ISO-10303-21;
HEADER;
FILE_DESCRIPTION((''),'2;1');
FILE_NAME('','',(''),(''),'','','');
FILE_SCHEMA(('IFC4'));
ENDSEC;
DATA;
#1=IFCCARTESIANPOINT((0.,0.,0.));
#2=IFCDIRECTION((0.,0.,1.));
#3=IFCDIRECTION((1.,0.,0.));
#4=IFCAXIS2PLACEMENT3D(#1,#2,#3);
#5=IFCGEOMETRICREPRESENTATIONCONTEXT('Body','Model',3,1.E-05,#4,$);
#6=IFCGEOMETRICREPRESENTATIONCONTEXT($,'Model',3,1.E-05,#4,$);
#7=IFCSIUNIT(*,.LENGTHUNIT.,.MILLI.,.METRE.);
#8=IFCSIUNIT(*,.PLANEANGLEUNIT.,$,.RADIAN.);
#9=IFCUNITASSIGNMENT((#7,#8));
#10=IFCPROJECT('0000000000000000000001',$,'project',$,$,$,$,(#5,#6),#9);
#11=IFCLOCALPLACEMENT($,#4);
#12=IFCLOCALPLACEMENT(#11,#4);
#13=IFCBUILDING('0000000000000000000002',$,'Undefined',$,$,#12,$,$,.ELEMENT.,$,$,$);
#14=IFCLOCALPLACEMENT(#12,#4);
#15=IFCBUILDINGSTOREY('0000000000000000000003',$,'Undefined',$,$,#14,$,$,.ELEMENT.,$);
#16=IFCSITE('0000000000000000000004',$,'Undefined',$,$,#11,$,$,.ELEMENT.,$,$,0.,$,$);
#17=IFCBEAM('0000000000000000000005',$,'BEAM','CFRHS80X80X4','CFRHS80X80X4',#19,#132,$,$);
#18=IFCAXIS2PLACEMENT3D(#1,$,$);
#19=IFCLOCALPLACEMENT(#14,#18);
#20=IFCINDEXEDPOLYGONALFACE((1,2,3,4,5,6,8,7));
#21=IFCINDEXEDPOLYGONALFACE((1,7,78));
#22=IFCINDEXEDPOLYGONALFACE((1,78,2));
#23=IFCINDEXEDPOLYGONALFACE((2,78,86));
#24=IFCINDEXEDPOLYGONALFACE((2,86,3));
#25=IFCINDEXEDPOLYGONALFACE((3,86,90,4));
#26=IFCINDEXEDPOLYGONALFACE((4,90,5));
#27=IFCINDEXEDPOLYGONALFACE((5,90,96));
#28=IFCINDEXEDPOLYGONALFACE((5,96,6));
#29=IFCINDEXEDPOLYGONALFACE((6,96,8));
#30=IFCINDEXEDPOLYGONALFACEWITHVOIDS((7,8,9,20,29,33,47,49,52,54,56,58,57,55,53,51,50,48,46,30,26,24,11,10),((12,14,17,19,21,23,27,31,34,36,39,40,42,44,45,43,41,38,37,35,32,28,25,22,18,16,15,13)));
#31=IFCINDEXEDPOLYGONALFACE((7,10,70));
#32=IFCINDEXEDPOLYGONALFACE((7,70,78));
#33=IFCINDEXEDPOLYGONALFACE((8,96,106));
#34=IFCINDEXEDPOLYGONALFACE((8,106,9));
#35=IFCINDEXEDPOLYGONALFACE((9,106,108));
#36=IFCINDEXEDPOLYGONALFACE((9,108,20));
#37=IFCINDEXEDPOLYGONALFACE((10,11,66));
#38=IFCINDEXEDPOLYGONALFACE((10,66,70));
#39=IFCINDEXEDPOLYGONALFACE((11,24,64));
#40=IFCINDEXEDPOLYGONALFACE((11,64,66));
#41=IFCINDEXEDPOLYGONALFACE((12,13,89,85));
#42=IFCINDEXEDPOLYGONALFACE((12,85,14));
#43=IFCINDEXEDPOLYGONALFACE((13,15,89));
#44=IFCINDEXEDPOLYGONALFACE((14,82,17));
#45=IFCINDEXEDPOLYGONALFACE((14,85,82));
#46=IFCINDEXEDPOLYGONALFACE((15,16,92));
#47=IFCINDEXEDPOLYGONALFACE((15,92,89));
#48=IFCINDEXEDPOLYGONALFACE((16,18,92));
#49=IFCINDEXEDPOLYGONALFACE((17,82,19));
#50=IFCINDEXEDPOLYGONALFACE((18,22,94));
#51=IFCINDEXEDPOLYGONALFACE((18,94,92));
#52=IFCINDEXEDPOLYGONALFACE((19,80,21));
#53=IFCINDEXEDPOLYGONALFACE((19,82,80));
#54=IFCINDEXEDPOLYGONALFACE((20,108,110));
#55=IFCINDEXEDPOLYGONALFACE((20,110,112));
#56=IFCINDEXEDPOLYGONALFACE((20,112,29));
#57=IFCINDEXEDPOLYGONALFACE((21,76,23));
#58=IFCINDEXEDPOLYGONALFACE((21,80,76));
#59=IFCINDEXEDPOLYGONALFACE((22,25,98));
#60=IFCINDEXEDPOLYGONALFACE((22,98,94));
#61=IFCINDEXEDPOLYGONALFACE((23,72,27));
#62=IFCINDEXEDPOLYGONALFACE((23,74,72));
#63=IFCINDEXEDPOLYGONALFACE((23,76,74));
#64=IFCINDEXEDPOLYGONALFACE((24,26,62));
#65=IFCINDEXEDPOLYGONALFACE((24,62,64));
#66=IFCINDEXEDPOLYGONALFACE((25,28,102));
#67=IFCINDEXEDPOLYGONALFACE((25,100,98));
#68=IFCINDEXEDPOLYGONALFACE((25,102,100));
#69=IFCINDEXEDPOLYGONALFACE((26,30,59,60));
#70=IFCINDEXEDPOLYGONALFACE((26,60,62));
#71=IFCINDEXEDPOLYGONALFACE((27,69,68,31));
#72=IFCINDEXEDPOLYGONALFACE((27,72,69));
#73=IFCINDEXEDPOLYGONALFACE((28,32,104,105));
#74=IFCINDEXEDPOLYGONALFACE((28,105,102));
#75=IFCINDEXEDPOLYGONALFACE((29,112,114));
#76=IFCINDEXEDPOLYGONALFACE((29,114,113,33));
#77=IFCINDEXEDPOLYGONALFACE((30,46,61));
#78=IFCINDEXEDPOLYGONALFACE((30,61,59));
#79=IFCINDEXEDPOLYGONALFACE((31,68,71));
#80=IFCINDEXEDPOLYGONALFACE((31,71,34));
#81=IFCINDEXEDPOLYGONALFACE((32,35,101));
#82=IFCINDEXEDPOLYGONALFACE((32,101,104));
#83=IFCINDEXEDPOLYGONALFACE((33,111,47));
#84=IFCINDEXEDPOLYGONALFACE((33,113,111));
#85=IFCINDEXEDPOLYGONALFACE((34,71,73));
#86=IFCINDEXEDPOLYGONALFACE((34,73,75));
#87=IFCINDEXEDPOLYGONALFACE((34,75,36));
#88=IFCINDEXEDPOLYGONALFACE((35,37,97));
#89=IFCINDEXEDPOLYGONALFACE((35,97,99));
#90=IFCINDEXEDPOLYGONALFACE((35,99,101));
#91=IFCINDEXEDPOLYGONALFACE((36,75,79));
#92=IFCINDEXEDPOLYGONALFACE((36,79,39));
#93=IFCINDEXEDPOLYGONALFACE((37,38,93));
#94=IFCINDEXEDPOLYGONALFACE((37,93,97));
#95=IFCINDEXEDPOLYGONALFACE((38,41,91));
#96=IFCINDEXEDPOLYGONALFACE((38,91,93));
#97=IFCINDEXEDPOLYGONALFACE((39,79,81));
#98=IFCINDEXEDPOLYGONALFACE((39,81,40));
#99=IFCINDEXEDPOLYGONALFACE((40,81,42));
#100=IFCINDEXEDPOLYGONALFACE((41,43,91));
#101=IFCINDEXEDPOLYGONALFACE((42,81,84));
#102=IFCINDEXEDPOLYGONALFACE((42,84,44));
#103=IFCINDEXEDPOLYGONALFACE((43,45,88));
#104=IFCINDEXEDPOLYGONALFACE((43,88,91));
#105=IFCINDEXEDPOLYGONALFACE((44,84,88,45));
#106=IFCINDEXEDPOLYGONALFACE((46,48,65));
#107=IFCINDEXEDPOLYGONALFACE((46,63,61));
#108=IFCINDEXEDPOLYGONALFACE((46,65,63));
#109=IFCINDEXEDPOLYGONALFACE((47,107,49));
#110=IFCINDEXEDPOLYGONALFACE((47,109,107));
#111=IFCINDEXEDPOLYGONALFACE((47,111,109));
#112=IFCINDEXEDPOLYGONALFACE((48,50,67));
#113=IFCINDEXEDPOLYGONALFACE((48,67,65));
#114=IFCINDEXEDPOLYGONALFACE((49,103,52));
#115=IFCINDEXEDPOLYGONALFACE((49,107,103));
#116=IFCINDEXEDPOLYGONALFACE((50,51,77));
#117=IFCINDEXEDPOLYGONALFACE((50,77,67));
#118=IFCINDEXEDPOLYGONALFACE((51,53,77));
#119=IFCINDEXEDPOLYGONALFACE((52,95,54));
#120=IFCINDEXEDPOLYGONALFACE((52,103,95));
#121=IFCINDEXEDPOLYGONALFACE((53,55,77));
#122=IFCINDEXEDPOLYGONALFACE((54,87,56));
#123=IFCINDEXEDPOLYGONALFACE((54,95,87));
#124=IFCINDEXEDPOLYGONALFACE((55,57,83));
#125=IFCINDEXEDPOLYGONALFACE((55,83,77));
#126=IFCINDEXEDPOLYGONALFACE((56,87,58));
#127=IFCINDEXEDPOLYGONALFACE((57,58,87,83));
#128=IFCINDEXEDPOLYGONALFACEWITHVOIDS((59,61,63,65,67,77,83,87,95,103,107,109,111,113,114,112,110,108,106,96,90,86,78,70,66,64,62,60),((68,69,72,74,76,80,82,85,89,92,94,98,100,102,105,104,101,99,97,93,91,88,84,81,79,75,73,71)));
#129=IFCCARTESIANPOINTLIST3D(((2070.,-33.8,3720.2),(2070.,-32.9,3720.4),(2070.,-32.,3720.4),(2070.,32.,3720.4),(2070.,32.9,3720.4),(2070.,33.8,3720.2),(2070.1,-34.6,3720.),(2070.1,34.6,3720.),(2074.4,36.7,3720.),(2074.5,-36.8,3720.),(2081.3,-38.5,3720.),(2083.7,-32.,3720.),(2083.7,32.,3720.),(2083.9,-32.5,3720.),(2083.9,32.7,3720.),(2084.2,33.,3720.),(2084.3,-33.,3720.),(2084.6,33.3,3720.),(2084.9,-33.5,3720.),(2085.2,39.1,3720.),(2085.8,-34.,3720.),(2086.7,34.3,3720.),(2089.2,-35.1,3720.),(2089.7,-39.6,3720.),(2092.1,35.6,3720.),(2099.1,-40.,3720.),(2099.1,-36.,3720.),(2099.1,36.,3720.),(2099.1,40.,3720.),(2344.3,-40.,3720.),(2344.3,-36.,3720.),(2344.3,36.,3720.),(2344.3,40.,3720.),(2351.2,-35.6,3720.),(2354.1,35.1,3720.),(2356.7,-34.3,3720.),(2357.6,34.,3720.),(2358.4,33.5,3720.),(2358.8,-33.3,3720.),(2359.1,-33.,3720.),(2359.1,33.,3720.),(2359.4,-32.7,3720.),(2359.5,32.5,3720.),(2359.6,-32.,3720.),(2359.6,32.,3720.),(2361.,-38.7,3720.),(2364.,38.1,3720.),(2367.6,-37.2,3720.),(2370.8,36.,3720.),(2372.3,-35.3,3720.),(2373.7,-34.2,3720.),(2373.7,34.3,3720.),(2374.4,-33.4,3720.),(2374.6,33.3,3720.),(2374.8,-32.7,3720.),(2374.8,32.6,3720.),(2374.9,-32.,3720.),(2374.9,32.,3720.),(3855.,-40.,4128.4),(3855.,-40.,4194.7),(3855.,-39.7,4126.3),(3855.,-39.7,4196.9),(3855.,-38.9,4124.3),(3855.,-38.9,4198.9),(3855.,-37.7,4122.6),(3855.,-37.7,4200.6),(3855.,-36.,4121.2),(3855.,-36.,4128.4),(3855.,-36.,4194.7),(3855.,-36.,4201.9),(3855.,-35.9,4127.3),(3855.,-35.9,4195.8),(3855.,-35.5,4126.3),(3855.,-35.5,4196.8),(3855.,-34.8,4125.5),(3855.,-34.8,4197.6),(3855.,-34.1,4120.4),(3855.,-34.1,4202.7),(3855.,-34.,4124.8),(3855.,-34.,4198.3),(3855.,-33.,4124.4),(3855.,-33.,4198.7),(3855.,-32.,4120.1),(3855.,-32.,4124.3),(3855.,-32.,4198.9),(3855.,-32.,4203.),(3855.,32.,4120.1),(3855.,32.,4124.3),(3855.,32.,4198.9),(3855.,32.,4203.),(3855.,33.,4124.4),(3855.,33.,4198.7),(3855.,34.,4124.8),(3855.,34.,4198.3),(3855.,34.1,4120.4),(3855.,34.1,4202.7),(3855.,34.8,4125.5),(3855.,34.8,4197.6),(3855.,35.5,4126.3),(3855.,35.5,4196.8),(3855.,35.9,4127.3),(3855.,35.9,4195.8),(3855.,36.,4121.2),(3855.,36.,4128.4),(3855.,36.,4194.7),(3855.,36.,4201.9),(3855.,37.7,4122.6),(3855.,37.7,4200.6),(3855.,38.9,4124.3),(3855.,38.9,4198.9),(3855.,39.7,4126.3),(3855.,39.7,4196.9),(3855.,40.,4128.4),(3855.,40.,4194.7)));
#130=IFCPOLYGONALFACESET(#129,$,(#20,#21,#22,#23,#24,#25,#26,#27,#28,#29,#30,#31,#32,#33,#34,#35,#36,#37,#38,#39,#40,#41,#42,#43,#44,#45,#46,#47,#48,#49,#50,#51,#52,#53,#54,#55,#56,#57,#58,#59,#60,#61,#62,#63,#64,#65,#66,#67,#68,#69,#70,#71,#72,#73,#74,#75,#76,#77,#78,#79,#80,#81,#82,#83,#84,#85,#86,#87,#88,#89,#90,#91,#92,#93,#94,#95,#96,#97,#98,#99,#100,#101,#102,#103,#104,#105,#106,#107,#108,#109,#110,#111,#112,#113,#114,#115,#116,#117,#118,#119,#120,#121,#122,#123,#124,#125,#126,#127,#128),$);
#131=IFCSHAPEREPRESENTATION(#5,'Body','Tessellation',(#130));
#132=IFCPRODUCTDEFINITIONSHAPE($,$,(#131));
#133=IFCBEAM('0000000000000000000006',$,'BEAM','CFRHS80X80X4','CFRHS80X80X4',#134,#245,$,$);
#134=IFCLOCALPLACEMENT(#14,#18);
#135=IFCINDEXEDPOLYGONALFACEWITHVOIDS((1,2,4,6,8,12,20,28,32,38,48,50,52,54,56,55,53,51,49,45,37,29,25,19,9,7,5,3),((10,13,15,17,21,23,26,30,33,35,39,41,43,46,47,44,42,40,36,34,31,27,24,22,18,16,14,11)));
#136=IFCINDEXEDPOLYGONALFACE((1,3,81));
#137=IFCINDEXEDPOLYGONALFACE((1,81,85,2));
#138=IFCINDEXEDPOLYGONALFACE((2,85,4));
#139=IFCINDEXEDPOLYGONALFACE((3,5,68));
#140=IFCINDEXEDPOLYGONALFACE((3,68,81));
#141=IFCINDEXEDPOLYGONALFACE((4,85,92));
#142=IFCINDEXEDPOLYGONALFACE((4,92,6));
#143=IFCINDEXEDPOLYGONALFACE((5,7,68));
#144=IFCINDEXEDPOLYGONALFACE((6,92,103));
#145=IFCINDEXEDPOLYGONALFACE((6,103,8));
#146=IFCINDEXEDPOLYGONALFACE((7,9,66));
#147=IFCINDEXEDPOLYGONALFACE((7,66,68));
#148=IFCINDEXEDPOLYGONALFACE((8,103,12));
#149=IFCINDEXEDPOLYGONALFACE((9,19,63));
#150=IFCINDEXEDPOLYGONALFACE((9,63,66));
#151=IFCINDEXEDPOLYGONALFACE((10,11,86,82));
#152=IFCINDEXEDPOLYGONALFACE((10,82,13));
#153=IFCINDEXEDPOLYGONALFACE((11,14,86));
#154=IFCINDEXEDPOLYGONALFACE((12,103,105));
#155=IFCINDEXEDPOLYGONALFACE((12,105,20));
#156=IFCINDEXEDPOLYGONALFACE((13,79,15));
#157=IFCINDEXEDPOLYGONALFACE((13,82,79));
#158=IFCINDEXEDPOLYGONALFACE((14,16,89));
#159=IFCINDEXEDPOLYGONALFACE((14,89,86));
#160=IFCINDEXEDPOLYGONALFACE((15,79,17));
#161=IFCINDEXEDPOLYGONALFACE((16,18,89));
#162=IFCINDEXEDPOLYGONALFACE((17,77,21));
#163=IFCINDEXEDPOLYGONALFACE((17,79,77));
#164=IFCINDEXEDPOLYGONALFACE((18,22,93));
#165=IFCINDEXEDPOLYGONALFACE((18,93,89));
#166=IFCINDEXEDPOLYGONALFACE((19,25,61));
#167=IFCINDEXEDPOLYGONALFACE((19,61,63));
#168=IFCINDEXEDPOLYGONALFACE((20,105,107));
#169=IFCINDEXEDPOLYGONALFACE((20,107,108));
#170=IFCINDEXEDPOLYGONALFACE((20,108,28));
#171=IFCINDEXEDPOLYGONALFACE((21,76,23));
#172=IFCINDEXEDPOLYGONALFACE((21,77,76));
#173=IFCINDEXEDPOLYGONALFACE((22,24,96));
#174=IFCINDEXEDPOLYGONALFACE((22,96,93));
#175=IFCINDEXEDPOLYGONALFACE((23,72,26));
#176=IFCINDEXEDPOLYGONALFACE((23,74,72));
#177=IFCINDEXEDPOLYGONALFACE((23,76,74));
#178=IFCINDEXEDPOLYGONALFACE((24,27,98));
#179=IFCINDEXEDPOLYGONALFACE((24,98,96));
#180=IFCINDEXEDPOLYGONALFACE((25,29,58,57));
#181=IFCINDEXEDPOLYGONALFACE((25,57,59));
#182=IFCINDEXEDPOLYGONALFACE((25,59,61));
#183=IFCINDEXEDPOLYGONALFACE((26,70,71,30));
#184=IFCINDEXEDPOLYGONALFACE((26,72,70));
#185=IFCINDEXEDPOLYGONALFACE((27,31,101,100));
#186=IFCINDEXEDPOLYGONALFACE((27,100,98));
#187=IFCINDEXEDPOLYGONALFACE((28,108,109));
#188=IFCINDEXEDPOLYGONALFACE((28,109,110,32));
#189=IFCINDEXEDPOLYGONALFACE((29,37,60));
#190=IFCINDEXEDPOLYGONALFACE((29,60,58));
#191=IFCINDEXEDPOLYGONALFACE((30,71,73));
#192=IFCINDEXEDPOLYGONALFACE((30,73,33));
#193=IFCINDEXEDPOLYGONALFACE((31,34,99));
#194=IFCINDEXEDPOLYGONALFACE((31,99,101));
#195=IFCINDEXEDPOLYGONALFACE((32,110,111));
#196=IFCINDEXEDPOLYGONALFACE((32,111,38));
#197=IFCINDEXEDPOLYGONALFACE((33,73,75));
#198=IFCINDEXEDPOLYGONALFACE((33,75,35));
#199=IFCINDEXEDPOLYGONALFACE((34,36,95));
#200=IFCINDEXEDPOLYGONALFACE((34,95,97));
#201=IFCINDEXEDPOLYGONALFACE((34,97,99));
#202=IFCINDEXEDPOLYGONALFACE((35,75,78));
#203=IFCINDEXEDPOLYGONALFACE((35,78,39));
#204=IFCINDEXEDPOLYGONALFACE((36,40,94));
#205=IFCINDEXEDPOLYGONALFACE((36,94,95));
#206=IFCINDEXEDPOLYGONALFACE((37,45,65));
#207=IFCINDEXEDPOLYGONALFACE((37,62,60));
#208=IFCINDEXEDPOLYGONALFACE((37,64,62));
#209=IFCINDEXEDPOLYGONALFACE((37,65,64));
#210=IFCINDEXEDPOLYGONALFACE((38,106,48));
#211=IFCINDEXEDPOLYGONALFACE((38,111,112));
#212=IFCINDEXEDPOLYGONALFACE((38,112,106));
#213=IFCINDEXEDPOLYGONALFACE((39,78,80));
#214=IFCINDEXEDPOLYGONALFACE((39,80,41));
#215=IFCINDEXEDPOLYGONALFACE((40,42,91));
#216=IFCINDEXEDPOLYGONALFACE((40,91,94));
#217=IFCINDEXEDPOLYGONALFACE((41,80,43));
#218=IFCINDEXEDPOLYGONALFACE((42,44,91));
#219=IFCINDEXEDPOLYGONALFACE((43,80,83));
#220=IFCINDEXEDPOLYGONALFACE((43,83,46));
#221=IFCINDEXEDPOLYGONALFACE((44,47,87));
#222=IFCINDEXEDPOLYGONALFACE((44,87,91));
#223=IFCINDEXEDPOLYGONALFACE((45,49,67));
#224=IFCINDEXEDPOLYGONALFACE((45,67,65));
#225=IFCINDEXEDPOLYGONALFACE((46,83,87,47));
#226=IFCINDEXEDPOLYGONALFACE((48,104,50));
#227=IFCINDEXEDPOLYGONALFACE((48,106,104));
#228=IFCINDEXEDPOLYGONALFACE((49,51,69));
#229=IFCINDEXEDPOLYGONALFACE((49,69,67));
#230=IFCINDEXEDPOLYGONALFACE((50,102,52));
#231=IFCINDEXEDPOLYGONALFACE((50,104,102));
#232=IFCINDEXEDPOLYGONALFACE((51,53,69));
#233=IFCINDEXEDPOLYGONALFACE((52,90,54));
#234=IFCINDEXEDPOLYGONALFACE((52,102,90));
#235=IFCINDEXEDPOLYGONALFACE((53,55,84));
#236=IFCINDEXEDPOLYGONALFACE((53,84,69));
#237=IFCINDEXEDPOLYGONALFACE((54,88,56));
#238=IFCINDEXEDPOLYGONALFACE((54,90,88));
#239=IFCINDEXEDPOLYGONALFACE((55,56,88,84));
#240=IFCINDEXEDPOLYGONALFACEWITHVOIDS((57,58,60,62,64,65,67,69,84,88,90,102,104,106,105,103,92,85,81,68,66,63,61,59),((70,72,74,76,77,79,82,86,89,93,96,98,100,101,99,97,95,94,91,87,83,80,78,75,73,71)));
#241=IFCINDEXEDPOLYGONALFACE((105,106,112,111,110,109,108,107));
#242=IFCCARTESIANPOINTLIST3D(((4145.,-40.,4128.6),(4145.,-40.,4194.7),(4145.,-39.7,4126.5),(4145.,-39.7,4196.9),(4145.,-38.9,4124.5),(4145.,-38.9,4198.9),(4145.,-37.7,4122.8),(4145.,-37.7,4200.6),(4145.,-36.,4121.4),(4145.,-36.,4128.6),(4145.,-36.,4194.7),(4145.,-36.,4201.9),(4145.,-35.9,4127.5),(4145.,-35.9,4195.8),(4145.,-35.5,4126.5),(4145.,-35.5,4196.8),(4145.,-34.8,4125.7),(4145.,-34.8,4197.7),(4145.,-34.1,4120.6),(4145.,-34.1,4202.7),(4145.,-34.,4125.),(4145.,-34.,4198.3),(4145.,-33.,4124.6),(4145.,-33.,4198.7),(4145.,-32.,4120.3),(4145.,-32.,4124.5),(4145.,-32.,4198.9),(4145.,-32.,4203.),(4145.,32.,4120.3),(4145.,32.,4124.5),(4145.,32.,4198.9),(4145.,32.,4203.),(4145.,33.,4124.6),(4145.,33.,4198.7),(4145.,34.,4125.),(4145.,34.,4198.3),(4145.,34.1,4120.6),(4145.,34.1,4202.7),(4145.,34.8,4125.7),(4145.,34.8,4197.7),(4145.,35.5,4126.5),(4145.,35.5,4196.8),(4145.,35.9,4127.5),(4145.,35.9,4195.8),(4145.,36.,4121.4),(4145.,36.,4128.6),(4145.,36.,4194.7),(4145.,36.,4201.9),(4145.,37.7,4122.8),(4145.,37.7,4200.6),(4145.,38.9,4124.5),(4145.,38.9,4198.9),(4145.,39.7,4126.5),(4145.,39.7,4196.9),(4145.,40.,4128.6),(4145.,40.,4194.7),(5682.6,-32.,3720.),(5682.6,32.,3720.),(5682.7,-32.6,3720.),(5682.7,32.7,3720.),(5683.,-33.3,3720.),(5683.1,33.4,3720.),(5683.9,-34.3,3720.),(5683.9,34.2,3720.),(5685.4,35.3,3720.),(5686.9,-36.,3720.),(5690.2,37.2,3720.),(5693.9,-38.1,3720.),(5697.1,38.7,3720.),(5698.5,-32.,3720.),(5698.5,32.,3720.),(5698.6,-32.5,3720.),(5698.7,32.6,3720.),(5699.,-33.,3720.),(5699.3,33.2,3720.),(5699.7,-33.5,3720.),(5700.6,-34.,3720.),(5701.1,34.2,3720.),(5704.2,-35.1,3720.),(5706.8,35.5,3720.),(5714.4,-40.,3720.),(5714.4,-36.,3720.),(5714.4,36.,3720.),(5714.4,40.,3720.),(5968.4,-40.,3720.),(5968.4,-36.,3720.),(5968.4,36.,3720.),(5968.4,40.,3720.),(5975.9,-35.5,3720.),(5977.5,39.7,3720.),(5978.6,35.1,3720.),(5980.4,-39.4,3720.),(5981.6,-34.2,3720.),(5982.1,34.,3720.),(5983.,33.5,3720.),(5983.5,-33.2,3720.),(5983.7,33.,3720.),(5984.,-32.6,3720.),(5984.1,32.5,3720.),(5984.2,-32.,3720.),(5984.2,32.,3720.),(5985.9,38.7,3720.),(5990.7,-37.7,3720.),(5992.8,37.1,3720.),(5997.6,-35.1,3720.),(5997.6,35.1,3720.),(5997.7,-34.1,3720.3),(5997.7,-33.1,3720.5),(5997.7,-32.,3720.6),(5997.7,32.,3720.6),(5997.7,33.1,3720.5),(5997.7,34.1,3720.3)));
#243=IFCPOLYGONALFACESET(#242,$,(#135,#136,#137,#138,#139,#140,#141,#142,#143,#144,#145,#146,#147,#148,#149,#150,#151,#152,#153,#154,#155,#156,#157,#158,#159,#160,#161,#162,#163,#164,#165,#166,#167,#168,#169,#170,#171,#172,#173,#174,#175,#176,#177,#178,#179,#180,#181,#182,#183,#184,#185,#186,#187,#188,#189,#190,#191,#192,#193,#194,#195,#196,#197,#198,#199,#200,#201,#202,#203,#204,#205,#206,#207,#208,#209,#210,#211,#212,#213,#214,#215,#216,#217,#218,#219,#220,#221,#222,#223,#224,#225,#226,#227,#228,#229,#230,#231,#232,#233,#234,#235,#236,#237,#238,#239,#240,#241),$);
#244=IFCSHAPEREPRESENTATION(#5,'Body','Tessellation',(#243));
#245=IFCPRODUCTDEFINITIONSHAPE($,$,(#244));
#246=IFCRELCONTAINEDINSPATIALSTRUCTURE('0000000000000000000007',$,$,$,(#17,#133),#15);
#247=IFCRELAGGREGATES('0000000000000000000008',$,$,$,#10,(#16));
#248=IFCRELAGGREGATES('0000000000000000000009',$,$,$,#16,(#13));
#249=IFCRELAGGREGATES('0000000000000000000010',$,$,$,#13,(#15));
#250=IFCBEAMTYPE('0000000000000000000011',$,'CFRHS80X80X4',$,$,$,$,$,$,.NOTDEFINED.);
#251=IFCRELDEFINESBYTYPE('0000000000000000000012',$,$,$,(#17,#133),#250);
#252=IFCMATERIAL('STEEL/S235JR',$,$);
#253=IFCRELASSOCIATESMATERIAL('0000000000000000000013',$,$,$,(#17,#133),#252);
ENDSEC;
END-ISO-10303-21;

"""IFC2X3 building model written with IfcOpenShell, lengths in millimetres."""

from ifc_helpers import new_model, si_unit, frame, origin_with_axes, origin_2d_with_axis, place, context, project, spatial, hollow_rectangle, extrude, clip, halfspace, material, type_object, element, save


model = new_model("IFC2X3")

# Units and contexts
model_context_1 = context("Model", 3, precision=1e-05, world=origin_with_axes(), identifier="Body")
model_context_2 = context("Model", 3, precision=1e-05, world=origin_with_axes())
ifc_project = project(units=[si_unit("LENGTHUNIT", "METRE", prefix="MILLI"), si_unit("PLANEANGLEUNIT", "RADIAN")], contexts=[model_context_1, model_context_2])

# Site, building, storey
site_placement = place(None, origin_with_axes())
site = spatial("IfcSite", under=ifc_project, at=site_placement, Name="Undefined", CompositionType="ELEMENT", RefElevation=0.0)
building_placement = place(site_placement, origin_with_axes())
building = spatial("IfcBuilding", under=site, at=building_placement, Name="Undefined", CompositionType="ELEMENT")
storey_placement = place(building_placement, origin_with_axes())
storey = spatial("IfcBuildingStorey", under=building, at=storey_placement, Name="Undefined", CompositionType="ELEMENT")

# Shared definitions
ifc_material = material(Name="STEEL/S235JR")

# Beams
beam_type_1 = type_object("IfcBeamType", Name="CFRHS80X80X4", PredefinedType="NOTDEFINED")
beam_1_placement = place(storey_placement, frame((3864.7, 0.0, 4164.2), z_axis=(0.0, -1.0, 0.0), x_axis=(-0.965344, 0.0, -0.260979)))
element("IfcBeam", 1, at=beam_1_placement, inside=storey, type_object=beam_type_1, material=ifc_material, Name="BEAM", Description="CFRHS80X80X4", ObjectType="CFRHS80X80X4", context=model_context_1, shape_type="Clipping", body=[
    clip(clip(extrude(hollow_rectangle(XDim=80.0, YDim=80.0, WallThickness=4.0, InnerFilletRadius=4.0, OuterFilletRadius=8.0, at=origin_2d_with_axis()), frame((1848.3, 0.0, 0.0), z_axis=(-1.0, 0.0, 0.0), x_axis=(0.0, -1.0, 0.0)), (0.0, 0.0, 1.0), 1997.1), halfspace(frame((1916.0, -57.8, -40.0), z_axis=(0.260979, 0.965344, 0.0), x_axis=(0.0, 0.0, 1.0)), False)), halfspace(frame((24.8, 54.3, 0.0), z_axis=(0.965344, -0.260979, 0.0), x_axis=(-0.260979, -0.965344, 0.0)), True)),
])
beam_2_placement = place(storey_placement, frame((4134.9, 0.0, 4164.3), z_axis=(0.0, -1.0, 0.0), x_axis=(0.967738, 0.0, -0.25196)))
element("IfcBeam", 2, at=beam_2_placement, inside=storey, type_object=beam_type_1, material=ifc_material, Name="BEAM", Description="CFRHS80X80X4", ObjectType="CFRHS80X80X4", context=model_context_1, shape_type="Clipping", body=[
    clip(clip(extrude(hollow_rectangle(XDim=80.0, YDim=80.0, WallThickness=4.0, InnerFilletRadius=4.0, OuterFilletRadius=8.0, at=origin_2d_with_axis()), frame((1914.5, 0.0, 0.0), z_axis=(-1.0, 0.0, 0.0), x_axis=(0.0, -1.0, 0.0)), (0.0, 0.0, 1.0), 2067.5), halfspace(frame((1916.8, 40.0, -40.0), z_axis=(0.25196, -0.967738, 0.0), x_axis=(-0.967738, -0.25196, 0.0)), False)), halfspace(frame((24.6, -54.6, 0.0), z_axis=(0.967738, 0.25196, 0.0), x_axis=(0.0, 0.0, 1.0)), True)),
])

save(model, "model.ifc")
